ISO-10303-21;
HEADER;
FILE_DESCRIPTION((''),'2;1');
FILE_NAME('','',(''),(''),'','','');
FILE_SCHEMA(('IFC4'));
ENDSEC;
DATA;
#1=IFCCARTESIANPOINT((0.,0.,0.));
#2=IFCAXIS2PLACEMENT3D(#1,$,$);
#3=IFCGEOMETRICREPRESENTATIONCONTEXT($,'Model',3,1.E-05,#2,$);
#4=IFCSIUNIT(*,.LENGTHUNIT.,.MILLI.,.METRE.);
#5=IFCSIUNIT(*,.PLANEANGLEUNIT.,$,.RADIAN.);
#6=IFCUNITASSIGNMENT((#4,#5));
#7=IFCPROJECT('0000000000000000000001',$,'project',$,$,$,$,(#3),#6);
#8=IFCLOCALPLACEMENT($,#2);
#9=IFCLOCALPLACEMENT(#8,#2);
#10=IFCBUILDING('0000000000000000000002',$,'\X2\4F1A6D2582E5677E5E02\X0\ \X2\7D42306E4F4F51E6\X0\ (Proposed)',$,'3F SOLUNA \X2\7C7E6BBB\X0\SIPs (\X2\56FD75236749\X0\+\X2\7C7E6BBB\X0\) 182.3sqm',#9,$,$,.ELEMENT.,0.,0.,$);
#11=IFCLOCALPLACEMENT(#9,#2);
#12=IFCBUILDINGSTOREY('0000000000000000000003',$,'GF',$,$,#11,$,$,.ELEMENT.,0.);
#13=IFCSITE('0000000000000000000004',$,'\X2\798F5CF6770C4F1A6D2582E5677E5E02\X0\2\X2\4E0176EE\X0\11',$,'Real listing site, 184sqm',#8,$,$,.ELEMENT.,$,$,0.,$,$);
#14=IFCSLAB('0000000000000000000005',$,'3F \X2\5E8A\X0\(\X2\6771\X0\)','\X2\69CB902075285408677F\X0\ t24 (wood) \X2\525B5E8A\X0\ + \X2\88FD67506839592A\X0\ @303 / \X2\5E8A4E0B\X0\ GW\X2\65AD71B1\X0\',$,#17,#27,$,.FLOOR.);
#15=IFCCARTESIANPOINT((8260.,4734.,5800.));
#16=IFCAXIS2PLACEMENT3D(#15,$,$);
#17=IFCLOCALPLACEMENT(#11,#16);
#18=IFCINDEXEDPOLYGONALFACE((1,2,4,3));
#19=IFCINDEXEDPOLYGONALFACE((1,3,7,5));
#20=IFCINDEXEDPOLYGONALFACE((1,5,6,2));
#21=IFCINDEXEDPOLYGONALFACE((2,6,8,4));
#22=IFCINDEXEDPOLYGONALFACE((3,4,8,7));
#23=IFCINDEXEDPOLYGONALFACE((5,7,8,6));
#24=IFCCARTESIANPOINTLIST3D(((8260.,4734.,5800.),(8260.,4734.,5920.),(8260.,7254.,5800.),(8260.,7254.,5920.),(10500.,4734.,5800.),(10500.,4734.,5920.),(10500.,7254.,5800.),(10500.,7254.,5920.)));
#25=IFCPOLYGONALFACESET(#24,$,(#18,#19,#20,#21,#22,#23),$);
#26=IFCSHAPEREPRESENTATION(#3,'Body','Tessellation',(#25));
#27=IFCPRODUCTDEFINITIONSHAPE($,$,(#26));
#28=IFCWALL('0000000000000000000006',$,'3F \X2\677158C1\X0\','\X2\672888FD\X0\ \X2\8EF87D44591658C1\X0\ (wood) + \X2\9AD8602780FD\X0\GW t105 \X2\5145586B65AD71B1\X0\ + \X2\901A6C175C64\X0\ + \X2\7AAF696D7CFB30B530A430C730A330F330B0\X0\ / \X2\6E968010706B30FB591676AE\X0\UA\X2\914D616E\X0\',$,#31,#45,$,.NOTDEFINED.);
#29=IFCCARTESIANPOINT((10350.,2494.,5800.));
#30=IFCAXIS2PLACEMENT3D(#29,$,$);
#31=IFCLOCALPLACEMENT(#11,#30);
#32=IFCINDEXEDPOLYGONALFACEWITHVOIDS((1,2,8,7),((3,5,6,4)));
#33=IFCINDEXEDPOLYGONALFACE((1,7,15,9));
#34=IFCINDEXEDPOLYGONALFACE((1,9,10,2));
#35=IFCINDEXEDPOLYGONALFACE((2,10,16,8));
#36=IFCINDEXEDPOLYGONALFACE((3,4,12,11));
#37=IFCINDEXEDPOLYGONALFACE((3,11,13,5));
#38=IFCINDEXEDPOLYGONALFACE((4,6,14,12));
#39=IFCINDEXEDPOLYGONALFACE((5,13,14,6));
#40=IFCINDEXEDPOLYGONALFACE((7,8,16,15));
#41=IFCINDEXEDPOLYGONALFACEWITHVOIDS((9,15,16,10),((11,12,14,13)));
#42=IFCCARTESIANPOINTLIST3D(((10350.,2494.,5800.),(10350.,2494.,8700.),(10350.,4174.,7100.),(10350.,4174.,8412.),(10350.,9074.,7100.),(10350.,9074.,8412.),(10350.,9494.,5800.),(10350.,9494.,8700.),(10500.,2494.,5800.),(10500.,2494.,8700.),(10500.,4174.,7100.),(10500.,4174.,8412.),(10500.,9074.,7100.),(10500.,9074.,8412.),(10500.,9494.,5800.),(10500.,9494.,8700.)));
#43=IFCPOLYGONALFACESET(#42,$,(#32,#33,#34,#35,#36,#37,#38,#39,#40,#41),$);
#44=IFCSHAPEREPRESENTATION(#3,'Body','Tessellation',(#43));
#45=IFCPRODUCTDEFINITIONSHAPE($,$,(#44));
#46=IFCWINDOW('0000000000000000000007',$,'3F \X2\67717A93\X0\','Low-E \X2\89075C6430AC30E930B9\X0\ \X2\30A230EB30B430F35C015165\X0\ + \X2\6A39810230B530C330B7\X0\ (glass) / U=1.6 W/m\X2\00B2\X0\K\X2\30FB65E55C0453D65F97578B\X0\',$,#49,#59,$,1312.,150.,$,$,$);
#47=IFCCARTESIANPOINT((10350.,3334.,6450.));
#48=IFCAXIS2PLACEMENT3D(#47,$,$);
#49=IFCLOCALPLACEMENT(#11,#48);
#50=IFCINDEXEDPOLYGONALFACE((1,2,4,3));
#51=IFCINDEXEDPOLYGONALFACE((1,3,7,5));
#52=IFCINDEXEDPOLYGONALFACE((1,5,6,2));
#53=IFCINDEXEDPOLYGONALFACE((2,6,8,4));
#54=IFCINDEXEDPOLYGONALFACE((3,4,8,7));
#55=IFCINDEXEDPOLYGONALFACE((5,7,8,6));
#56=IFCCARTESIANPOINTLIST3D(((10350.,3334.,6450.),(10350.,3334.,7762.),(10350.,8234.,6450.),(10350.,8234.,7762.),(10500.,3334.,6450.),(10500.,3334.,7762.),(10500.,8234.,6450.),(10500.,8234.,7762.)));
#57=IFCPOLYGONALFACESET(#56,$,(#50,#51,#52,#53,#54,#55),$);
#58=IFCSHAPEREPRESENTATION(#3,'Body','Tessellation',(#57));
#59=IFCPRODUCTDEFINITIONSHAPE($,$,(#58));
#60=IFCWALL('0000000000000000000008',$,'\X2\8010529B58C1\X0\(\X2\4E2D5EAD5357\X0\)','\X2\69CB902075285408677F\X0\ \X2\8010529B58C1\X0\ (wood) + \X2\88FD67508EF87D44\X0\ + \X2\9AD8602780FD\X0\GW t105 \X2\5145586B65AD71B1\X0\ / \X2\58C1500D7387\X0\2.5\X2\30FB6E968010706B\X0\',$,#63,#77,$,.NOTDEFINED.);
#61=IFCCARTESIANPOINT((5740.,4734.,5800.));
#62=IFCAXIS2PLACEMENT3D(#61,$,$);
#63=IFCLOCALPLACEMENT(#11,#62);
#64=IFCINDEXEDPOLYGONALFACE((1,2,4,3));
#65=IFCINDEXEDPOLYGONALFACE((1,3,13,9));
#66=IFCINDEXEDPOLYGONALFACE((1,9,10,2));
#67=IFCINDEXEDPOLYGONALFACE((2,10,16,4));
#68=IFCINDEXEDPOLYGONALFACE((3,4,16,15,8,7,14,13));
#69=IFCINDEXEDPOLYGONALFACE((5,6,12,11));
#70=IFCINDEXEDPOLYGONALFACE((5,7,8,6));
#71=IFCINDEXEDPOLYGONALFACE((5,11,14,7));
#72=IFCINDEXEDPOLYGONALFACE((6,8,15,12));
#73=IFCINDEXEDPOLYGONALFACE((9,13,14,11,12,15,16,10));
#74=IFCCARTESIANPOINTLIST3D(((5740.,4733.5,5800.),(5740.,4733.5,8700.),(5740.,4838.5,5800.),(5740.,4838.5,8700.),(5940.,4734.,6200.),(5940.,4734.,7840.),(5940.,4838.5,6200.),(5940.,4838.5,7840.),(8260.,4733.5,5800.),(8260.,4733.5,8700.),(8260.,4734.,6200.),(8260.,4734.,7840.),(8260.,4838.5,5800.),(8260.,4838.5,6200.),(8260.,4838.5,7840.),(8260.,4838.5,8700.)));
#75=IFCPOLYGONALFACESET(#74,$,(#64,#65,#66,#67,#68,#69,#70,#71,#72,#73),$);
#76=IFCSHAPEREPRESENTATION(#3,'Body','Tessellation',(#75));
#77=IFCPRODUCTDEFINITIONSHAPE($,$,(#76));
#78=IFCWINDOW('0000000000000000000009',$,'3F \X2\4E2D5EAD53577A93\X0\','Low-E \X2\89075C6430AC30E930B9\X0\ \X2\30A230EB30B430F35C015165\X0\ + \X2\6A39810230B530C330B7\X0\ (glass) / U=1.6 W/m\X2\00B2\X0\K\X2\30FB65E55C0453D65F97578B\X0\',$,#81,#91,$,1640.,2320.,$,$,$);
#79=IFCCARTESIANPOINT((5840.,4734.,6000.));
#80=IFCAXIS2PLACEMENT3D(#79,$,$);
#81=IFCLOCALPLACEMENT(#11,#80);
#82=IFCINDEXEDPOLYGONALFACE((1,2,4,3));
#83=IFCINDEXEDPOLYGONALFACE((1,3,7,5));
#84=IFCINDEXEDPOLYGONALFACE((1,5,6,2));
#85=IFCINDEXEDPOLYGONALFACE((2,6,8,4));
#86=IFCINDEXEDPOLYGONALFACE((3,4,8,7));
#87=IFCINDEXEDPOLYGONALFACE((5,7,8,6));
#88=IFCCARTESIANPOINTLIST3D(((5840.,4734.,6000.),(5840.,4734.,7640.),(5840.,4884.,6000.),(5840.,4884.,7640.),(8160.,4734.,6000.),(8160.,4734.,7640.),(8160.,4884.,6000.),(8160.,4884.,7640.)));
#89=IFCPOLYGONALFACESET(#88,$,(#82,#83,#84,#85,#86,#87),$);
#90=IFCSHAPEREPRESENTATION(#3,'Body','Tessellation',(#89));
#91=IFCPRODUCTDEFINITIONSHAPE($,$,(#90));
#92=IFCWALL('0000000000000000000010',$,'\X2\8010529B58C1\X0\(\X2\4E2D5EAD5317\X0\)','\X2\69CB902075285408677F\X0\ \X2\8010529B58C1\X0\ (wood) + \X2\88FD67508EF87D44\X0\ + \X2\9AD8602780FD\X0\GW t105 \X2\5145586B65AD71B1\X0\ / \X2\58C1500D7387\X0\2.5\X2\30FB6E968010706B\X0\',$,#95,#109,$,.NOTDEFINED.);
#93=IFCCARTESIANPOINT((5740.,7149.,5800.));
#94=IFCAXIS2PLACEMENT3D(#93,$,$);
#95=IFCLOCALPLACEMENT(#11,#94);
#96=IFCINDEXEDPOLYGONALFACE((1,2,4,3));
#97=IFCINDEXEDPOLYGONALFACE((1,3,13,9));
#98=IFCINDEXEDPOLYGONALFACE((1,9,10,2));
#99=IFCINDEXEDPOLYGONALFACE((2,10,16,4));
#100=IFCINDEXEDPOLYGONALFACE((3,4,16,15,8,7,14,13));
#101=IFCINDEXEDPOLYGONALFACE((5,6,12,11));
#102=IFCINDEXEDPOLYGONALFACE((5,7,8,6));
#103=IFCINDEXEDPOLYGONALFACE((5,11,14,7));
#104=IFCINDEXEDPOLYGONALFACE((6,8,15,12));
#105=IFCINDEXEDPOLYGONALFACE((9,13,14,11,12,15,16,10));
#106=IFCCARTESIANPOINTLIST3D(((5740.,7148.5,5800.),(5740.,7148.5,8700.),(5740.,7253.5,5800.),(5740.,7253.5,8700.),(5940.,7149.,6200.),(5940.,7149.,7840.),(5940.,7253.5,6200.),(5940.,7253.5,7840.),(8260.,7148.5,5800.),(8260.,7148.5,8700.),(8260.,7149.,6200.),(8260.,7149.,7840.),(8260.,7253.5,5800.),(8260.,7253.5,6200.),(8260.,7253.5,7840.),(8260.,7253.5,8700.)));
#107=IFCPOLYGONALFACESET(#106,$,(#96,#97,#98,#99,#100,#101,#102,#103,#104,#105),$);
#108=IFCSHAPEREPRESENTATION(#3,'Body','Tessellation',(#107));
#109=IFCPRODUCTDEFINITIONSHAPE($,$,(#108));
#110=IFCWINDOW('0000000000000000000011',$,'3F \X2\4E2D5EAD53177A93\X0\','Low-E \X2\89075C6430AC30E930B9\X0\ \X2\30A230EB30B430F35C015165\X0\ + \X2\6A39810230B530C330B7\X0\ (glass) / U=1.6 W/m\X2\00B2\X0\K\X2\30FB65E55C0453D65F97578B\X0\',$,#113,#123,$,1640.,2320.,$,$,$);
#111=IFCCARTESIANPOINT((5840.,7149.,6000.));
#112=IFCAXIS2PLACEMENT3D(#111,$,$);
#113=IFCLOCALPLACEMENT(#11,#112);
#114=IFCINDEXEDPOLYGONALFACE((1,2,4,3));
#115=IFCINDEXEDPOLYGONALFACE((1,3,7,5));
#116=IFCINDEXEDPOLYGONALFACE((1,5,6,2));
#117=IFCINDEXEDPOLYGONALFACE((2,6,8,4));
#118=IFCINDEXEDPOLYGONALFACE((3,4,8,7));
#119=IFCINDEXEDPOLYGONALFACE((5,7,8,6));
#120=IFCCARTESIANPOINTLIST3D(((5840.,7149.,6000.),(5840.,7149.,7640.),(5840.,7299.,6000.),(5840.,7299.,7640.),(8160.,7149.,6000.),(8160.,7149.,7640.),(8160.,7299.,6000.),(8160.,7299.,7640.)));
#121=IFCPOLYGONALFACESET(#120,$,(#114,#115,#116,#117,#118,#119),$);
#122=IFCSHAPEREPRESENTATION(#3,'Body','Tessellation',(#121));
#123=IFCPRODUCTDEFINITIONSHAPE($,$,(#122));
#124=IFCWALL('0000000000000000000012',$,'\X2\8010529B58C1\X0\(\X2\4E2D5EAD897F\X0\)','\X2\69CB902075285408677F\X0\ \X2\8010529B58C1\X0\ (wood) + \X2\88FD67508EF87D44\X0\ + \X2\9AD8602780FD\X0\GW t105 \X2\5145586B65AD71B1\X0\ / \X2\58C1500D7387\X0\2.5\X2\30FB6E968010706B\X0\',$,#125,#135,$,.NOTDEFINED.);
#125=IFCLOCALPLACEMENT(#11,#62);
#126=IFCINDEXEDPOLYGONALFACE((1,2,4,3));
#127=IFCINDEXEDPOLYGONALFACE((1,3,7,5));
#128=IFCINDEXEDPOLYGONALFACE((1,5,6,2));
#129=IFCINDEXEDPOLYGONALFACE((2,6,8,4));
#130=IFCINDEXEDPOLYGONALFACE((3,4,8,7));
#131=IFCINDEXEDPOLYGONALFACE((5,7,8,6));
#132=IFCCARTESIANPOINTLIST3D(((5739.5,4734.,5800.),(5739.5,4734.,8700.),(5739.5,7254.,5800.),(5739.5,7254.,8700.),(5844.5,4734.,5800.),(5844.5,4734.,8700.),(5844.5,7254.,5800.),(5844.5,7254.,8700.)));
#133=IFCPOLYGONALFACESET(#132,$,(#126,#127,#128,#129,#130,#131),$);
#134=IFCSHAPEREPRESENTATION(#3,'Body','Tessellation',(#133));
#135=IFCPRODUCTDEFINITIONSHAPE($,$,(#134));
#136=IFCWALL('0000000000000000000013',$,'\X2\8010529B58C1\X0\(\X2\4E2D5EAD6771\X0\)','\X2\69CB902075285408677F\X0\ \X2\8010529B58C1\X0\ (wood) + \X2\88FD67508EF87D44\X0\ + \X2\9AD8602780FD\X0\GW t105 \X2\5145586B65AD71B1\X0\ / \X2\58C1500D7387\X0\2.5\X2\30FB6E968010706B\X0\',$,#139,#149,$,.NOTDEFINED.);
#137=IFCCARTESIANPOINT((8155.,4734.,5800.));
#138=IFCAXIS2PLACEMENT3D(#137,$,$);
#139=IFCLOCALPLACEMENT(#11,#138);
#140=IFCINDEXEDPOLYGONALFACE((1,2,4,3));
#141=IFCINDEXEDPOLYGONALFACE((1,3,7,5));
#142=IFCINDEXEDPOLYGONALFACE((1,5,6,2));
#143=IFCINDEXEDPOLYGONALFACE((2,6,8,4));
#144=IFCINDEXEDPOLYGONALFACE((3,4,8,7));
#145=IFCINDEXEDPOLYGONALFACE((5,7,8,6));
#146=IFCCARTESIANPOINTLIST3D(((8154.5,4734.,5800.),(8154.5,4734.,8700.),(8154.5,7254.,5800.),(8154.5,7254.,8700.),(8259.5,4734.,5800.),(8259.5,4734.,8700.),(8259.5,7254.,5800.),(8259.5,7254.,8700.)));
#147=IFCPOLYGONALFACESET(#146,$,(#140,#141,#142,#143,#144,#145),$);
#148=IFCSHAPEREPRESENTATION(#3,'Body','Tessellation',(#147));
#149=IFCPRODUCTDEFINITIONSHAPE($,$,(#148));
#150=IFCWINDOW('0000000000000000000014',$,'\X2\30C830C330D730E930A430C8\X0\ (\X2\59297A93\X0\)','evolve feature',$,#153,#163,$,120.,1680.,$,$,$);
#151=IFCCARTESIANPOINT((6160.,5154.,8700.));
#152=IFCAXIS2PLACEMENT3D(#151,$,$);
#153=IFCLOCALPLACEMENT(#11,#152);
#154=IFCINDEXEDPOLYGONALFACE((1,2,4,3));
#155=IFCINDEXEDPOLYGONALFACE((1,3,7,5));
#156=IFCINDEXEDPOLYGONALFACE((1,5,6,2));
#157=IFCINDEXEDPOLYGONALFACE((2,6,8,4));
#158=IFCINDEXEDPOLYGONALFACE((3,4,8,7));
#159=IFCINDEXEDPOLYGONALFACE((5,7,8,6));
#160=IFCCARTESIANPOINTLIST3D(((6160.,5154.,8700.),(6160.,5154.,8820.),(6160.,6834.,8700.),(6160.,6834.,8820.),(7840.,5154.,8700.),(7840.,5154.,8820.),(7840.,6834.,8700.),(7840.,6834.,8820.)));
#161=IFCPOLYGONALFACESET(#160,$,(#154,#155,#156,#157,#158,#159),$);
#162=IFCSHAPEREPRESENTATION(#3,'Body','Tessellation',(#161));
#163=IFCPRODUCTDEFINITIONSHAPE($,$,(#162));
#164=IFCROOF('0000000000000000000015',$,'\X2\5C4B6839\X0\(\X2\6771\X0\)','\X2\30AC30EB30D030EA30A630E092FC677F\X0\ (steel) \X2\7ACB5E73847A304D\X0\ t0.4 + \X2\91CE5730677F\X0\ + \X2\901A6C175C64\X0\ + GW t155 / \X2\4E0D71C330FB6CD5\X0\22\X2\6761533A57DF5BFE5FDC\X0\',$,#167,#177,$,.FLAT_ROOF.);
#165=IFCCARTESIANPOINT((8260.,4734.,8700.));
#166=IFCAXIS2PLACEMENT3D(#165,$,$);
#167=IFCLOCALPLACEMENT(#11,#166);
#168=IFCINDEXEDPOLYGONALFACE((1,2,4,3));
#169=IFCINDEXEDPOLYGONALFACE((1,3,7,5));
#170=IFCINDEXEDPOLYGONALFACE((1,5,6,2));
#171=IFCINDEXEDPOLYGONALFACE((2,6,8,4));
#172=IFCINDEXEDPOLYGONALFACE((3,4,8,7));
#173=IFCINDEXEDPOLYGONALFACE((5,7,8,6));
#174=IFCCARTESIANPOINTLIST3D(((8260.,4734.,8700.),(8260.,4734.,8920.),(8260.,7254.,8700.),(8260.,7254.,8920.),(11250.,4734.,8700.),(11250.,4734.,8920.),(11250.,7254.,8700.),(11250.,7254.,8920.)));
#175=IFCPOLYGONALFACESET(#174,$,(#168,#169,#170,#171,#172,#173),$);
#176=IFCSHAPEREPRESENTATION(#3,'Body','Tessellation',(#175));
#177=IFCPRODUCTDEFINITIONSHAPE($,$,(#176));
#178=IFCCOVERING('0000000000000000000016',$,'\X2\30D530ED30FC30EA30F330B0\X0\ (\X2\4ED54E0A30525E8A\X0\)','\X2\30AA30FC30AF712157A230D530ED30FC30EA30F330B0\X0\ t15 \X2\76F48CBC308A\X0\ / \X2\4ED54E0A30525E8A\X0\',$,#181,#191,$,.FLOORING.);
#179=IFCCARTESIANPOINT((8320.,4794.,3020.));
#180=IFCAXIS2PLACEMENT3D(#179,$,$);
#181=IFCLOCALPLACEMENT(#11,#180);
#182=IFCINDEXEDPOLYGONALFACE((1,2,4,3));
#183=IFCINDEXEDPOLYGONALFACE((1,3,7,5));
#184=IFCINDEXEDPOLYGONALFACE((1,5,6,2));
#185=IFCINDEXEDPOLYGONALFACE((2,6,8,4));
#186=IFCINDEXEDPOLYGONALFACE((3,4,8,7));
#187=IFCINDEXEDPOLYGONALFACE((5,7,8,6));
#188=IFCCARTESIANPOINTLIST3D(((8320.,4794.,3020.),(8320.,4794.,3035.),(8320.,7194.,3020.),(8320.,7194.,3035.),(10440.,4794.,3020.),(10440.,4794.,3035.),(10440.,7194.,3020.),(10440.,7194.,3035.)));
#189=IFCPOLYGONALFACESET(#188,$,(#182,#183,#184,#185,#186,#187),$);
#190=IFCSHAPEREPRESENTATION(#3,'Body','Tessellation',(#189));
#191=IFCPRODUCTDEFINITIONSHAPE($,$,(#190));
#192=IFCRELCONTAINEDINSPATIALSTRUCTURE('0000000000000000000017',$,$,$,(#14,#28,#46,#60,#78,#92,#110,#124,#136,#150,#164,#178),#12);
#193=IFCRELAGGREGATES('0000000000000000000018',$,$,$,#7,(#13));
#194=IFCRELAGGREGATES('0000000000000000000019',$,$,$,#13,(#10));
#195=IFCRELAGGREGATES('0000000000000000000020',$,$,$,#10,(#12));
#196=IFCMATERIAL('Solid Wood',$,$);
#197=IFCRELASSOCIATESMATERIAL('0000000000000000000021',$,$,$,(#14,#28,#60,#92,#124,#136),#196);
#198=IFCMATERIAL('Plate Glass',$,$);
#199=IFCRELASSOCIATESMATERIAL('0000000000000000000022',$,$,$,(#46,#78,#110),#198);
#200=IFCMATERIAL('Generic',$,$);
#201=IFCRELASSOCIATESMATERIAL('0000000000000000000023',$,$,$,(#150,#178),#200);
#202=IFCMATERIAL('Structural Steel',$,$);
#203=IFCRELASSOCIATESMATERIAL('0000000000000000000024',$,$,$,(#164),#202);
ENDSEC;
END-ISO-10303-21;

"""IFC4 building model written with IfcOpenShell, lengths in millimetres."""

from ifc_helpers import new_model, si_unit, frame, frame_2d, origin, place, context, project, spatial, rectangle, extrude, material, element, fill, save


model = new_model("IFC4")

# Units and contexts
model_context = context("Model", 3, precision=1e-05, world=origin())
ifc_project = project(units=[si_unit("LENGTHUNIT", "METRE", prefix="MILLI"), si_unit("PLANEANGLEUNIT", "RADIAN")], contexts=[model_context])

# Site, building, storey
site_placement = place(None, origin())
site = spatial("IfcSite", under=ifc_project, at=site_placement, Name="福島県会津若松市2丁目11", ObjectType="Real listing site, 184sqm", CompositionType="ELEMENT", RefElevation=0.0)
building_placement = place(site_placement, origin())
building = spatial("IfcBuilding", under=site, at=building_placement, Name="会津若松市 終の住処 (Proposed)", ObjectType="3F SOLUNA 籾殻SIPs (国産杉+籾殻) 182.3sqm", CompositionType="ELEMENT", ElevationOfRefHeight=0.0, ElevationOfTerrain=0.0)
storey_placement = place(building_placement, origin())
storey = spatial("IfcBuildingStorey", under=building, at=storey_placement, Name="GF", CompositionType="ELEMENT", Elevation=0.0)

# Slab
ifc_material_1 = material(Name="Solid Wood")
slab_placement = place(storey_placement, frame((8260.0, 4734.0, 5800.0)))
element("IfcSlab", 1, at=slab_placement, inside=storey, material=ifc_material_1, Name="3F 床(東)", Description="構造用合板 t24 (wood) 剛床 + 製材根太 @303 / 床下 GW断熱", PredefinedType="FLOOR", context=model_context, shape_type="SweptSolid", body=[
    extrude(rectangle(XDim=2240.0, YDim=2520.0, at=frame_2d((1120.0, 1260.0))), frame((8260.0, 4734.0, 5800.0)), (0.0, 0.0, 1.0), 120.0),
])

# Walls, openings, windows
wall_1_placement = place(storey_placement, frame((10350.0, 2494.0, 5800.0)))
wall_1 = element("IfcWall", 2, at=wall_1_placement, inside=storey, material=ifc_material_1, Name="3F 東壁", Description="木製 軸組外壁 (wood) + 高性能GW t105 充填断熱 + 通気層 + 窯業系サイディング / 準耐火・外皮UA配慮", PredefinedType="NOTDEFINED", context=model_context, shape_type="SweptSolid", body=[
    extrude(rectangle(XDim=150.0, YDim=7000.0, at=frame_2d((75.0, 3500.0))), frame((10350.0, 2494.0, 5800.0)), (0.0, 0.0, 1.0), 2900.0),
])
opening_1_placement = place(storey_placement, frame((10350.0, 3334.0, 6450.0)))
opening_1 = element("IfcOpeningElement", 3, at=opening_1_placement, cuts=wall_1, PredefinedType="NOTDEFINED", context=model_context, shape_type="SweptSolid", body=[
    extrude(rectangle(XDim=150.0, YDim=4900.0, at=frame_2d((75.0, 2450.0))), frame((10350.0, 3334.0, 6450.0)), (0.0, 0.0, 1.0), 1312.0),
])
ifc_material_2 = material(Name="Plate Glass")
window_1_placement = place(storey_placement, frame((10350.0, 3334.0, 6450.0)))
window_1 = element("IfcWindow", 4, at=window_1_placement, inside=storey, material=ifc_material_2, Name="3F 東窓", Description="Low-E 複層ガラス アルゴン封入 + 樹脂サッシ (glass) / U=1.6 W/m²K・日射取得型", OverallHeight=1312.0, OverallWidth=150.0, context=model_context, shape_type="SweptSolid", body=[
    extrude(rectangle(XDim=150.0, YDim=4900.0, at=frame_2d((75.0, 2450.0))), frame((10350.0, 3334.0, 6450.0)), (0.0, 0.0, 1.0), 1312.0),
])
fill(opening_1, window_1)
wall_2_placement = place(storey_placement, frame((5740.0, 4734.0, 5800.0)))
wall_2 = element("IfcWall", 5, at=wall_2_placement, inside=storey, material=ifc_material_1, Name="耐力壁(中庭南)", Description="構造用合板 耐力壁 (wood) + 製材軸組 + 高性能GW t105 充填断熱 / 壁倍率2.5・準耐火", PredefinedType="NOTDEFINED", context=model_context, shape_type="SweptSolid", body=[
    extrude(rectangle(XDim=2520.0, YDim=105.0, at=frame_2d((1260.0, 52.0))), frame((5740.0, 4734.0, 5800.0)), (0.0, 0.0, 1.0), 2900.0),
])
opening_2_placement = place(storey_placement, frame((5840.0, 4734.0, 6000.0)))
opening_2 = element("IfcOpeningElement", 6, at=opening_2_placement, cuts=wall_2, PredefinedType="NOTDEFINED", context=model_context, shape_type="SweptSolid", body=[
    extrude(rectangle(XDim=2320.0, YDim=150.0, at=frame_2d((1160.0, 75.0))), frame((5840.0, 4734.0, 6000.0)), (0.0, 0.0, 1.0), 1640.0),
])
window_2_placement = place(storey_placement, frame((5840.0, 4734.0, 6000.0)))
window_2 = element("IfcWindow", 7, at=window_2_placement, inside=storey, material=ifc_material_2, Name="3F 中庭南窓", Description="Low-E 複層ガラス アルゴン封入 + 樹脂サッシ (glass) / U=1.6 W/m²K・日射取得型", OverallHeight=1640.0, OverallWidth=2320.0, context=model_context, shape_type="SweptSolid", body=[
    extrude(rectangle(XDim=2320.0, YDim=150.0, at=frame_2d((1160.0, 75.0))), frame((5840.0, 4734.0, 6000.0)), (0.0, 0.0, 1.0), 1640.0),
])
fill(opening_2, window_2)
wall_3_placement = place(storey_placement, frame((5740.0, 7149.0, 5800.0)))
wall_3 = element("IfcWall", 8, at=wall_3_placement, inside=storey, material=ifc_material_1, Name="耐力壁(中庭北)", Description="構造用合板 耐力壁 (wood) + 製材軸組 + 高性能GW t105 充填断熱 / 壁倍率2.5・準耐火", PredefinedType="NOTDEFINED", context=model_context, shape_type="SweptSolid", body=[
    extrude(rectangle(XDim=2520.0, YDim=105.0, at=frame_2d((1260.0, 52.0))), frame((5740.0, 7149.0, 5800.0)), (0.0, 0.0, 1.0), 2900.0),
])
opening_3_placement = place(storey_placement, frame((5840.0, 7149.0, 6000.0)))
opening_3 = element("IfcOpeningElement", 9, at=opening_3_placement, cuts=wall_3, PredefinedType="NOTDEFINED", context=model_context, shape_type="SweptSolid", body=[
    extrude(rectangle(XDim=2320.0, YDim=150.0, at=frame_2d((1160.0, 75.0))), frame((5840.0, 7149.0, 6000.0)), (0.0, 0.0, 1.0), 1640.0),
])
window_3_placement = place(storey_placement, frame((5840.0, 7149.0, 6000.0)))
window_3 = element("IfcWindow", 10, at=window_3_placement, inside=storey, material=ifc_material_2, Name="3F 中庭北窓", Description="Low-E 複層ガラス アルゴン封入 + 樹脂サッシ (glass) / U=1.6 W/m²K・日射取得型", OverallHeight=1640.0, OverallWidth=2320.0, context=model_context, shape_type="SweptSolid", body=[
    extrude(rectangle(XDim=2320.0, YDim=150.0, at=frame_2d((1160.0, 75.0))), frame((5840.0, 7149.0, 6000.0)), (0.0, 0.0, 1.0), 1640.0),
])
fill(opening_3, window_3)

# Walls
wall_4_placement = place(storey_placement, frame((5740.0, 4734.0, 5800.0)))
element("IfcWall", 11, at=wall_4_placement, inside=storey, material=ifc_material_1, Name="耐力壁(中庭西)", Description="構造用合板 耐力壁 (wood) + 製材軸組 + 高性能GW t105 充填断熱 / 壁倍率2.5・準耐火", PredefinedType="NOTDEFINED", context=model_context, shape_type="SweptSolid", body=[
    extrude(rectangle(XDim=105.0, YDim=2520.0, at=frame_2d((52.0, 1260.0))), frame((5740.0, 4734.0, 5800.0)), (0.0, 0.0, 1.0), 2900.0),
])
wall_5_placement = place(storey_placement, frame((8155.0, 4734.0, 5800.0)))
element("IfcWall", 12, at=wall_5_placement, inside=storey, material=ifc_material_1, Name="耐力壁(中庭東)", Description="構造用合板 耐力壁 (wood) + 製材軸組 + 高性能GW t105 充填断熱 / 壁倍率2.5・準耐火", PredefinedType="NOTDEFINED", context=model_context, shape_type="SweptSolid", body=[
    extrude(rectangle(XDim=105.0, YDim=2520.0, at=frame_2d((52.0, 1260.0))), frame((8155.0, 4734.0, 5800.0)), (0.0, 0.0, 1.0), 2900.0),
])

# Window
ifc_material_3 = material(Name="Generic")
window_4_placement = place(storey_placement, frame((6160.0, 5154.0, 8700.0)))
element("IfcWindow", 13, at=window_4_placement, inside=storey, material=ifc_material_3, Name="トップライト (天窓)", Description="evolve feature", OverallHeight=120.0, OverallWidth=1680.0, context=model_context, shape_type="SweptSolid", body=[
    extrude(rectangle(XDim=1680.0, YDim=1680.0, at=frame_2d((840.0, 840.0))), frame((6160.0, 5154.0, 8700.0)), (0.0, 0.0, 1.0), 120.0),
])

# Roof
ifc_material_4 = material(Name="Structural Steel")
for number, where, name in (
    (14, (8260.0, 4734.0, 8700.0), "屋根(東)"),
):
    element("IfcRoof", number, at=place(storey_placement, frame(where)), inside=storey, material=ifc_material_4, Name=name, Description="ガルバリウム鋼板 (steel) 立平葺き t0.4 + 野地板 + 通気層 + GW t155 / 不燃・法22条区域対応", PredefinedType="FLAT_ROOF", context=model_context, shape_type="SweptSolid", body=[
        extrude(rectangle(XDim=2990.0, YDim=2520.0, at=frame_2d((1495.0, 1260.0))), frame((8260.0, 4734.0, 8700.0)), (0.0, 0.0, 1.0), 220.0),
    ])

# Covering
covering_1_placement = place(storey_placement, frame((8320.0, 4794.0, 3020.0)))
element("IfcCovering", 15, at=covering_1_placement, inside=storey, material=ifc_material_3, Name="フローリング (仕上げ床)", Description="オーク無垢フローリング t15 直貼り / 仕上げ床", PredefinedType="FLOORING", context=model_context, shape_type="SweptSolid", body=[
    extrude(rectangle(XDim=2120.0, YDim=2400.0, at=frame_2d((1060.0, 1200.0))), frame((8320.0, 4794.0, 3020.0)), (0.0, 0.0, 1.0), 15.0),
])

save(model, "model.ifc")
